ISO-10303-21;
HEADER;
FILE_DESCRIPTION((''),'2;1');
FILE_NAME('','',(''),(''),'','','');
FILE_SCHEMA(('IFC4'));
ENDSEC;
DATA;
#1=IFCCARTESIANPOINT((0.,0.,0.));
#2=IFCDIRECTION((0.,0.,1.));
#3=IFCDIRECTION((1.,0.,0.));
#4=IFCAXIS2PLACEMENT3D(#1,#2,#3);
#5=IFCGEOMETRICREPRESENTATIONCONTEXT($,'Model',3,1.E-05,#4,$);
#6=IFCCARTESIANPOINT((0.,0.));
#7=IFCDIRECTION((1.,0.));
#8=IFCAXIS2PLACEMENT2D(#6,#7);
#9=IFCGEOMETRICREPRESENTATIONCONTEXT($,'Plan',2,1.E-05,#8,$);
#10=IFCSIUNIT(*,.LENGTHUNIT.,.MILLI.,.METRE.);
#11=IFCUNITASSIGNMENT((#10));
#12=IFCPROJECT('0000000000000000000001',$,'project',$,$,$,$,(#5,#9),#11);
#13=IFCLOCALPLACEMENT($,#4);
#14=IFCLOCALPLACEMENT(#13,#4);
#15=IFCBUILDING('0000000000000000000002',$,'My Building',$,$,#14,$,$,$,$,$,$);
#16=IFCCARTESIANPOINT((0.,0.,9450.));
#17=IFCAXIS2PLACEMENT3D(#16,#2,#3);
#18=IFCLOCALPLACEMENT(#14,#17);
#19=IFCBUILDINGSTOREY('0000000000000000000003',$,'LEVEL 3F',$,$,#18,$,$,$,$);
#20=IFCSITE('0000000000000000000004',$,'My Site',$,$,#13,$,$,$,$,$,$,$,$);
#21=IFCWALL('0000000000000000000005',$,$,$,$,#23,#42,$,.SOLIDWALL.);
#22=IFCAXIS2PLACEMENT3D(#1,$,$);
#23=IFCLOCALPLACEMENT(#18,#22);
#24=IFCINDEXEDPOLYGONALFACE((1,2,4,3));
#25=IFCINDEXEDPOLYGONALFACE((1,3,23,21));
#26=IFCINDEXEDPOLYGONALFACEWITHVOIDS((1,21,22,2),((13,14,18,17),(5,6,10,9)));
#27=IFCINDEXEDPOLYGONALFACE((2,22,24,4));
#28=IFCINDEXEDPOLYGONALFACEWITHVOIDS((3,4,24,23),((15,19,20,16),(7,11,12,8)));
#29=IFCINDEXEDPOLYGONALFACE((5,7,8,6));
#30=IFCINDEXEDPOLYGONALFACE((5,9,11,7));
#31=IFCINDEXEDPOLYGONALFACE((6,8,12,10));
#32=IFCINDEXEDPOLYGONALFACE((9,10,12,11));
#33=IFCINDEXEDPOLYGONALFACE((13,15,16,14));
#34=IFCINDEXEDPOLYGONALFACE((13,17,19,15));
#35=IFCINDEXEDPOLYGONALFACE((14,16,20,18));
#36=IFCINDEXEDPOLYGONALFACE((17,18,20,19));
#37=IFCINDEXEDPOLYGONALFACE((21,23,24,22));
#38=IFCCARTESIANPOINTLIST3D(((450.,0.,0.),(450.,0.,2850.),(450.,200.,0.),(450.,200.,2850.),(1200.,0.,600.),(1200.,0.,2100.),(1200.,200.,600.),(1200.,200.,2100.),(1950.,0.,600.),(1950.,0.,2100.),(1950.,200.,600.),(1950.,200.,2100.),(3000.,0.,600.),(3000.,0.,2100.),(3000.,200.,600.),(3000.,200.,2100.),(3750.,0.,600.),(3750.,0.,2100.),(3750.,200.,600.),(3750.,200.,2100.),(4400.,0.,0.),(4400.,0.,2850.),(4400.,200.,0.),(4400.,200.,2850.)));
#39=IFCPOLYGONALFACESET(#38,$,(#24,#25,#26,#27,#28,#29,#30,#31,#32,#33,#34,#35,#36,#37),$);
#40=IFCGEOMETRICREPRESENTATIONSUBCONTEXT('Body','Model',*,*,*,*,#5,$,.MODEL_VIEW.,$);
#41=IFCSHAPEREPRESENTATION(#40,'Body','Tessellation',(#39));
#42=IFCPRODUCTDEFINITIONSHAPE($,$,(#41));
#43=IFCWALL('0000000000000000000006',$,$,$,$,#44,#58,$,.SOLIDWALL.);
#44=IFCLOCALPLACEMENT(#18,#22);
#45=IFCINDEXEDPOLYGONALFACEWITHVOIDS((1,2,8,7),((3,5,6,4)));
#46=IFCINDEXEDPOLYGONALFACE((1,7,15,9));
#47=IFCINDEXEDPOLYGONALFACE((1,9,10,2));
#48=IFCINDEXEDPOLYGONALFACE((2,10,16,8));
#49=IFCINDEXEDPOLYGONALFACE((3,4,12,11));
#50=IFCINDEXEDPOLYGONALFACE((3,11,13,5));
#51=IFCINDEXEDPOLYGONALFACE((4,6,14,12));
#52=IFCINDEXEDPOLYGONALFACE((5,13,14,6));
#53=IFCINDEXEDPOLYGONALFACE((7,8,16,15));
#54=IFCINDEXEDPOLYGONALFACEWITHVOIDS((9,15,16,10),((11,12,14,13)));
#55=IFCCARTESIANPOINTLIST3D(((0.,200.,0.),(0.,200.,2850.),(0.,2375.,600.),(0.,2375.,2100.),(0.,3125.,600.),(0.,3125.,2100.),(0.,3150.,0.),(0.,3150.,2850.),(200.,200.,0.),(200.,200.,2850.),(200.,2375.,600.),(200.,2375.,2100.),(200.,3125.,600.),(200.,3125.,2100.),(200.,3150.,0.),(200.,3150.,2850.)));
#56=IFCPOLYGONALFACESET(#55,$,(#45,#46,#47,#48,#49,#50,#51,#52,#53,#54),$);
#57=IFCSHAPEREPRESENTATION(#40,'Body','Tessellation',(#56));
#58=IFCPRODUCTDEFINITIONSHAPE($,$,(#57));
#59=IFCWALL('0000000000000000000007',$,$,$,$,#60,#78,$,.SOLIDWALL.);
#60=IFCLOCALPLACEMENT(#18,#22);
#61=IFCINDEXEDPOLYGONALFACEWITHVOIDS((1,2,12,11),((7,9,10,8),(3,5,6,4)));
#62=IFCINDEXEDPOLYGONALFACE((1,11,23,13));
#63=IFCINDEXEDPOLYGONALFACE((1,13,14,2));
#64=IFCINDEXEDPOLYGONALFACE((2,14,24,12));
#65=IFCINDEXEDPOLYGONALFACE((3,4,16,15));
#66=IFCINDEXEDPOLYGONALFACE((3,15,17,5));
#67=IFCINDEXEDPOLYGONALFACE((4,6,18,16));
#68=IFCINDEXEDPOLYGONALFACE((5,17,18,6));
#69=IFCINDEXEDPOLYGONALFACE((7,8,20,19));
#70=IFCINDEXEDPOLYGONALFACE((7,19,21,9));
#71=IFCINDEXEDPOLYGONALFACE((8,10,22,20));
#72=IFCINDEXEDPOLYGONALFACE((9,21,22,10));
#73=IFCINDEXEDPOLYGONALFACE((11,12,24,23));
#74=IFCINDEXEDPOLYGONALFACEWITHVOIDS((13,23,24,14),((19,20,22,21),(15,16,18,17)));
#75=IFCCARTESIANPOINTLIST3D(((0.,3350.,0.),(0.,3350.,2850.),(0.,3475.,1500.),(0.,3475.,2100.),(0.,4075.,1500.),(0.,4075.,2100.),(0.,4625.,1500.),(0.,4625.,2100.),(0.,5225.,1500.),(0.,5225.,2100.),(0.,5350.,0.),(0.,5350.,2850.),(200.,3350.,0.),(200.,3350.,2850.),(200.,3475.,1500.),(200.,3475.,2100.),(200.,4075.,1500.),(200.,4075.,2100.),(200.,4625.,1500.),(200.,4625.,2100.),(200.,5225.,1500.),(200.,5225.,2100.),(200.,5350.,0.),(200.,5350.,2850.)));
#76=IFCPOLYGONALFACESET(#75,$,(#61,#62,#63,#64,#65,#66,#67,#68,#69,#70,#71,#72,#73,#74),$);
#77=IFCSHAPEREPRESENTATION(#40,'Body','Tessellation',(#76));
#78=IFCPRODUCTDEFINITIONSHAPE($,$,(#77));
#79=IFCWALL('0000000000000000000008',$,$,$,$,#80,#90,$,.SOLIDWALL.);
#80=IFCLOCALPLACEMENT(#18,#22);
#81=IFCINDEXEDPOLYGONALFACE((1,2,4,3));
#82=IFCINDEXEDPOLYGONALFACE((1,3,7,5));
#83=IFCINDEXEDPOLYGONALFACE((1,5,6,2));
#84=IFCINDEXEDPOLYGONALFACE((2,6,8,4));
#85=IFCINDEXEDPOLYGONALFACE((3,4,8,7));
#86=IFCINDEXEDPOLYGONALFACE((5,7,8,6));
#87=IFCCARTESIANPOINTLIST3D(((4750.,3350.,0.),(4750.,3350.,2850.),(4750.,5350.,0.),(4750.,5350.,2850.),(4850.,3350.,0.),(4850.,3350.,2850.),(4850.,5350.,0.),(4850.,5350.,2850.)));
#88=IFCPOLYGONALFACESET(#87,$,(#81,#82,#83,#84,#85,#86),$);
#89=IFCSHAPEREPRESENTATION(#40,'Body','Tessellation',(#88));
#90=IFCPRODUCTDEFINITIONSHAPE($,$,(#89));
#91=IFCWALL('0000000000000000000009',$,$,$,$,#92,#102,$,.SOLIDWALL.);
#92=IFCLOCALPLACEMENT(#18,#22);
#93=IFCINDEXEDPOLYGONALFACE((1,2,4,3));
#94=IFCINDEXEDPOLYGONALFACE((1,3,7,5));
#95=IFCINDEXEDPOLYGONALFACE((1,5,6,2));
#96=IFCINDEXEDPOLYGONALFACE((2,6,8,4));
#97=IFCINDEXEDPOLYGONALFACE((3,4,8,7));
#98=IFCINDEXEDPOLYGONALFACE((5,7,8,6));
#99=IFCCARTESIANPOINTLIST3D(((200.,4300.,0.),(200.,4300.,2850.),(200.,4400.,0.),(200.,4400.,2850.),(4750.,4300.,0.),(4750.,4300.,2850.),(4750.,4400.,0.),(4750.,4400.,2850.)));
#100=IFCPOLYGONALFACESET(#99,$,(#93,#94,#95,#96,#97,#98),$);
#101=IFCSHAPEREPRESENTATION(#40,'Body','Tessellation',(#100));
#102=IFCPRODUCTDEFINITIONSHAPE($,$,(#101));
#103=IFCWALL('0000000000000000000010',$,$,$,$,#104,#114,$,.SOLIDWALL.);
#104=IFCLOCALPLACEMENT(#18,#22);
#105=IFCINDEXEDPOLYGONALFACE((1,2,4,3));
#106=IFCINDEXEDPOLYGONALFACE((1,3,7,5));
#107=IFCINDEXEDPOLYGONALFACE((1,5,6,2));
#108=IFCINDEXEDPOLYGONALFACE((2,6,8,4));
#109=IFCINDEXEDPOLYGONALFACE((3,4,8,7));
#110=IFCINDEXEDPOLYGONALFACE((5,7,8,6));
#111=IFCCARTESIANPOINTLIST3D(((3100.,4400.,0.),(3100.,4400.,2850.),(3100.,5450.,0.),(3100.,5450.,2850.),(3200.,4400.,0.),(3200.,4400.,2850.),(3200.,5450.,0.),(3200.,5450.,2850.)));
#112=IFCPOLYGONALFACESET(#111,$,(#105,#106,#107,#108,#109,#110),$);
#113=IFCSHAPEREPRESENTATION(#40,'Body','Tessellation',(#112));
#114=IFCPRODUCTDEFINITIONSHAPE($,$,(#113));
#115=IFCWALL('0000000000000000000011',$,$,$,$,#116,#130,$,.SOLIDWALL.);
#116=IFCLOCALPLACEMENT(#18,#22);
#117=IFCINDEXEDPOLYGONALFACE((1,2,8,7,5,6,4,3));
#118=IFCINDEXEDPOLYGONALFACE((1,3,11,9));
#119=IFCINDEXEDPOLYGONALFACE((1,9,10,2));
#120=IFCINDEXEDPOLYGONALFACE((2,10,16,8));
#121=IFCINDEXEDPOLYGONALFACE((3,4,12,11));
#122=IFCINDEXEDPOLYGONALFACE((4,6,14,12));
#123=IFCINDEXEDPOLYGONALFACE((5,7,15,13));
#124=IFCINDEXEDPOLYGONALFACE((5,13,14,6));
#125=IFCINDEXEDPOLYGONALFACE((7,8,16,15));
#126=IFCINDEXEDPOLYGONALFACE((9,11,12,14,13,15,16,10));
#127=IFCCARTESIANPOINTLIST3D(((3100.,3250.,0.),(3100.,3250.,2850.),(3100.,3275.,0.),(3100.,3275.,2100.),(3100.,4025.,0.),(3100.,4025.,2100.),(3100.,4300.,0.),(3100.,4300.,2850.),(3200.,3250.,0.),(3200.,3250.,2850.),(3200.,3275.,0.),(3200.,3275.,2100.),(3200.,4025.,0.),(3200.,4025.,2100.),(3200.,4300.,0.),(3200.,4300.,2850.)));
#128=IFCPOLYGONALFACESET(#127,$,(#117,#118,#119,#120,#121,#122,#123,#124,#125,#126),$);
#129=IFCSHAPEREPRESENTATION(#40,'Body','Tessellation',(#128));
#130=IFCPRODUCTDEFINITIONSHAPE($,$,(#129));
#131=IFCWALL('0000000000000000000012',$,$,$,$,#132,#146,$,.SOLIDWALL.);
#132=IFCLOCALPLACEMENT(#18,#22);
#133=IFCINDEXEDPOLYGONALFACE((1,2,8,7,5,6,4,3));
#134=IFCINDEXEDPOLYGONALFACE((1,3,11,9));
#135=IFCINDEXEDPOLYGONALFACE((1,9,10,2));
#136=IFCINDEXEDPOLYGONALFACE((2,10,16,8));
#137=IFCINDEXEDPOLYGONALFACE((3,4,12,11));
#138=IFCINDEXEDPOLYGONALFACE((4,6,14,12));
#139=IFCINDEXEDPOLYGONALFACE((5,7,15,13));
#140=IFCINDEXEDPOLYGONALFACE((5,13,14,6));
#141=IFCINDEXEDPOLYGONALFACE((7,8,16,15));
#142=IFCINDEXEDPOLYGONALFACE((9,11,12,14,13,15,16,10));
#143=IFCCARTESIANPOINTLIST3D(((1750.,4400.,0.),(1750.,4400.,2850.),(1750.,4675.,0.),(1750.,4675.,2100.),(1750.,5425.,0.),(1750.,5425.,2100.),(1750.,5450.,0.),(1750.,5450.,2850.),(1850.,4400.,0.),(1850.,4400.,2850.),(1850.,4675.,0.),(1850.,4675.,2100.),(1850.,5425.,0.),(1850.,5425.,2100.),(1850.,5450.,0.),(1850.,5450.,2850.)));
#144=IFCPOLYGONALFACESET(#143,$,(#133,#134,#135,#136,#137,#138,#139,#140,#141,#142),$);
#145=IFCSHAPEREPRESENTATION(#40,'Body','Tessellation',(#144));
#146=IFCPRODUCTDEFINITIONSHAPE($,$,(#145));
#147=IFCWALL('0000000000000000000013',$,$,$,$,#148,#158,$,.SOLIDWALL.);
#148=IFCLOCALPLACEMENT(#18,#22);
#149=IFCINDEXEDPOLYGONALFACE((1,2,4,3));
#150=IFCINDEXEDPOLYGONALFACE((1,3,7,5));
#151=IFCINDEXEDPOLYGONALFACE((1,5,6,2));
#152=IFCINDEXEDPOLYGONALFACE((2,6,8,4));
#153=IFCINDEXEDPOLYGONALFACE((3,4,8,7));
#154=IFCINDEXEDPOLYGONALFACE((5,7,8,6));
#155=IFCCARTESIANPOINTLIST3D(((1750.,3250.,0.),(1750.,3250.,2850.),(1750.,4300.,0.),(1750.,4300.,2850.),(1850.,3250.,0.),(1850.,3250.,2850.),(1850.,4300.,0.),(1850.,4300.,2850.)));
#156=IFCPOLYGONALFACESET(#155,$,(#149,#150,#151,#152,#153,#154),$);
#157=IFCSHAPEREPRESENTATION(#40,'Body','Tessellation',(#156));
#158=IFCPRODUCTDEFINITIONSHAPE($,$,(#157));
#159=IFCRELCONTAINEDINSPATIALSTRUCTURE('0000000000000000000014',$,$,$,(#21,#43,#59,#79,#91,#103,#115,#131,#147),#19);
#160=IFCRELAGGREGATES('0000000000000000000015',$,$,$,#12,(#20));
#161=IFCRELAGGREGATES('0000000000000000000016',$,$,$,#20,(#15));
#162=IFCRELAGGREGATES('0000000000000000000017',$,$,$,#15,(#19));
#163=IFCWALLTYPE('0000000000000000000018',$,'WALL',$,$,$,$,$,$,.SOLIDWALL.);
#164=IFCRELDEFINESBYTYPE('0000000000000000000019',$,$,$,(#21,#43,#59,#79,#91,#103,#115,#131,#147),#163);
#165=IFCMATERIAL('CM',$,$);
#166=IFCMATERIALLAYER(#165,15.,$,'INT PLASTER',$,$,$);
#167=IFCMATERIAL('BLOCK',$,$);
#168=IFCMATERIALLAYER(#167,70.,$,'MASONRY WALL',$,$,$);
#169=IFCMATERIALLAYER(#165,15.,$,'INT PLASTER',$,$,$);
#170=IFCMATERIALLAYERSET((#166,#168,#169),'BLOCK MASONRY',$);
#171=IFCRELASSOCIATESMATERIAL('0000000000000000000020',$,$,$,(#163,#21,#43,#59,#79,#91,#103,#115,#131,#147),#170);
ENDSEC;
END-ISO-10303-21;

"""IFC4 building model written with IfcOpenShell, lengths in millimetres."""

from ifc_helpers import new_model, si_unit, frame, origin_with_axes, origin_2d_with_axis, place, context, subcontext, project, spatial, indexed_curve, outline, extrude, material, layer, layer_set, layer_usage, type_object, element, save


model = new_model("IFC4")

# Units and contexts
model_context = context("Model", 3, precision=1e-05, world=origin_with_axes())
plan_context = context("Plan", 2, precision=1e-05, world=origin_2d_with_axis())
body_context = subcontext(model_context, "Body", "Model", "MODEL_VIEW")
ifc_project = project(units=[si_unit("LENGTHUNIT", "METRE", prefix="MILLI")], contexts=[model_context, plan_context])

# Site, building, storey
site_placement = place(None, origin_with_axes())
site = spatial("IfcSite", under=ifc_project, at=site_placement, Name="My Site")
building_placement = place(site_placement, origin_with_axes())
building = spatial("IfcBuilding", under=site, at=building_placement, Name="My Building")
storey_placement = place(building_placement, frame((0.0, 0.0, 9450.0), z_axis=(0.0, 0.0, 1.0), x_axis=(1.0, 0.0, 0.0)))
storey = spatial("IfcBuildingStorey", under=building, at=storey_placement, Name="LEVEL 3F")

# Shared definitions
ifc_material_1 = material(Name="CM")
ifc_layer_1 = layer(ifc_material_1, 15.0, Name="INT PLASTER")
ifc_material_2 = material(Name="BLOCK")
ifc_layer_2 = layer(ifc_material_2, 70.0, Name="MASONRY WALL")
ifc_layer_3 = layer(ifc_material_1, 15.0, Name="INT PLASTER")
ifc_layer_set_1 = layer_set([ifc_layer_1, ifc_layer_2, ifc_layer_3], Name="BLOCK MASONRY")
wall_type = type_object("IfcWallType", Name="WALL", PredefinedType="SOLIDWALL", material=ifc_layer_set_1)

# Wall, openings
ifc_layer_usage_1 = layer_usage(ifc_layer_set_1, "AXIS2", "POSITIVE", 0.0)
wall_1_placement = place(storey_placement, frame((450.0, 200.0, 0.0), z_axis=(0.0, 0.0, 1.0), x_axis=(0.0, -1.0, 0.0)))
wall_1 = element("IfcWall", 1, at=wall_1_placement, inside=storey, type_object=wall_type, material=ifc_layer_usage_1, PredefinedType="SOLIDWALL", context=body_context, shape_type="SweptSolid", body=[
    extrude(outline(indexed_curve([(0.0, 0.0), (0.0, 3950.0), (200.0, 3950.0), (200.0, 0.0), (0.0, 0.0)], self_intersect=False)), origin_with_axes(), (0.0, 0.0, 1.0), 2850.0),
])
opening_1_placement = place(wall_1_placement, frame((0.0, 1500.0, 600.0), z_axis=(0.0, 0.0, 1.0), x_axis=(0.0, -1.0, 0.0)))
element("IfcOpeningElement", 2, at=opening_1_placement, cuts=wall_1, PredefinedType="OPENING", context=body_context, shape_type="SweptSolid", body=[
    extrude(outline(indexed_curve([(0.0, 0.0), (0.0, 400.0), (750.0, 400.0), (750.0, 0.0), (0.0, 0.0)], self_intersect=False)), frame((0.0, -100.0, 0.0), z_axis=(0.0, 0.0, 1.0), x_axis=(1.0, 0.0, 0.0)), (0.0, 0.0, 1.0), 1500.0),
])
opening_2_placement = place(wall_1_placement, frame((0.0, 3300.0, 600.0), z_axis=(0.0, 0.0, 1.0), x_axis=(0.0, -1.0, 0.0)))
element("IfcOpeningElement", 3, at=opening_2_placement, cuts=wall_1, PredefinedType="OPENING", context=body_context, shape_type="SweptSolid", body=[
    extrude(outline(indexed_curve([(0.0, 0.0), (0.0, 400.0), (750.0, 400.0), (750.0, 0.0), (0.0, 0.0)], self_intersect=False)), frame((0.0, -100.0, 0.0), z_axis=(0.0, 0.0, 1.0), x_axis=(1.0, 0.0, 0.0)), (0.0, 0.0, 1.0), 1500.0),
])

# Wall, opening
ifc_layer_usage_2 = layer_usage(ifc_layer_set_1, "AXIS2", "POSITIVE", 0.0)
wall_2_placement = place(storey_placement, frame((200.0, 200.0, 0.0), z_axis=(0.0, 0.0, 1.0), x_axis=(0.0, 1.0, 0.0)))
wall_2 = element("IfcWall", 4, at=wall_2_placement, inside=storey, type_object=wall_type, material=ifc_layer_usage_2, PredefinedType="SOLIDWALL", context=body_context, shape_type="SweptSolid", body=[
    extrude(outline(indexed_curve([(0.0, 0.0), (0.0, 200.0), (2950.0, 200.0), (2950.0, 0.0), (0.0, 0.0)], self_intersect=False)), origin_with_axes(), (0.0, 0.0, 1.0), 2850.0),
])
opening_3_placement = place(wall_2_placement, frame((2175.0, 0.0, 600.0), z_axis=(0.0, 0.0, 1.0), x_axis=(1.0, 0.0, 0.0)))
element("IfcOpeningElement", 5, at=opening_3_placement, cuts=wall_2, PredefinedType="OPENING", context=body_context, shape_type="SweptSolid", body=[
    extrude(outline(indexed_curve([(0.0, 0.0), (0.0, 400.0), (750.0, 400.0), (750.0, 0.0), (0.0, 0.0)], self_intersect=False)), frame((0.0, -100.0, 0.0), z_axis=(0.0, 0.0, 1.0), x_axis=(1.0, 0.0, 0.0)), (0.0, 0.0, 1.0), 1500.0),
])

# Wall, openings
ifc_layer_usage_3 = layer_usage(ifc_layer_set_1, "AXIS2", "POSITIVE", 0.0)
wall_3_placement = place(storey_placement, frame((200.0, 3350.0, 0.0), z_axis=(0.0, 0.0, 1.0), x_axis=(0.0, 1.0, 0.0)))
wall_3 = element("IfcWall", 6, at=wall_3_placement, inside=storey, type_object=wall_type, material=ifc_layer_usage_3, PredefinedType="SOLIDWALL", context=body_context, shape_type="SweptSolid", body=[
    extrude(outline(indexed_curve([(0.0, 0.0), (0.0, 200.0), (2000.0, 200.0), (2000.0, 0.0), (0.0, 0.0)], self_intersect=False)), origin_with_axes(), (0.0, 0.0, 1.0), 2850.0),
])
opening_4_placement = place(wall_3_placement, frame((1275.0, 0.0, 1500.0), z_axis=(0.0, 0.0, 1.0), x_axis=(1.0, 0.0, 0.0)))
element("IfcOpeningElement", 7, at=opening_4_placement, cuts=wall_3, PredefinedType="OPENING", context=body_context, shape_type="SweptSolid", body=[
    extrude(outline(indexed_curve([(0.0, 0.0), (0.0, 400.0), (600.0, 400.0), (600.0, 0.0), (0.0, 0.0)], self_intersect=False)), frame((0.0, -100.0, 0.0), z_axis=(0.0, 0.0, 1.0), x_axis=(1.0, 0.0, 0.0)), (0.0, 0.0, 1.0), 600.0),
])
opening_5_placement = place(wall_3_placement, frame((125.0, 0.0, 1500.0), z_axis=(0.0, 0.0, 1.0), x_axis=(1.0, 0.0, 0.0)))
element("IfcOpeningElement", 8, at=opening_5_placement, cuts=wall_3, PredefinedType="OPENING", context=body_context, shape_type="SweptSolid", body=[
    extrude(outline(indexed_curve([(0.0, 0.0), (0.0, 400.0), (600.0, 400.0), (600.0, 0.0), (0.0, 0.0)], self_intersect=False)), frame((0.0, -100.0, 0.0), z_axis=(0.0, 0.0, 1.0), x_axis=(1.0, 0.0, 0.0)), (0.0, 0.0, 1.0), 600.0),
])

# Walls
ifc_layer_usage_4 = layer_usage(ifc_layer_set_1, "AXIS2", "POSITIVE", 0.0)
wall_4_placement = place(storey_placement, frame((4850.0, 3350.0, 0.0), z_axis=(0.0, 0.0, 1.0), x_axis=(0.0, 1.0, 0.0)))
element("IfcWall", 9, at=wall_4_placement, inside=storey, type_object=wall_type, material=ifc_layer_usage_4, PredefinedType="SOLIDWALL", context=body_context, shape_type="SweptSolid", body=[
    extrude(outline(indexed_curve([(0.0, 0.0), (0.0, 100.0), (2000.0, 100.0), (2000.0, 0.0), (0.0, 0.0)], self_intersect=False)), origin_with_axes(), (0.0, 0.0, 1.0), 2850.0),
])
ifc_layer_usage_5 = layer_usage(ifc_layer_set_1, "AXIS2", "POSITIVE", 0.0)
wall_5_placement = place(storey_placement, frame((200.0, 4400.0, 0.0), z_axis=(0.0, 0.0, 1.0), x_axis=(0.0, -1.0, 0.0)))
element("IfcWall", 10, at=wall_5_placement, inside=storey, type_object=wall_type, material=ifc_layer_usage_5, PredefinedType="SOLIDWALL", context=body_context, shape_type="SweptSolid", body=[
    extrude(outline(indexed_curve([(0.0, 0.0), (0.0, 4550.0), (100.0, 4550.0), (100.0, 0.0), (0.0, 0.0)], self_intersect=False)), origin_with_axes(), (0.0, 0.0, 1.0), 2850.0),
])
ifc_layer_usage_6 = layer_usage(ifc_layer_set_1, "AXIS2", "POSITIVE", 0.0)
wall_6_placement = place(storey_placement, frame((3200.0, 4400.0, 0.0), z_axis=(0.0, 0.0, 1.0), x_axis=(0.0, 1.0, 0.0)))
element("IfcWall", 11, at=wall_6_placement, inside=storey, type_object=wall_type, material=ifc_layer_usage_6, PredefinedType="SOLIDWALL", context=body_context, shape_type="SweptSolid", body=[
    extrude(outline(indexed_curve([(0.0, 0.0), (0.0, 100.0), (1050.0, 100.0), (1050.0, 0.0), (0.0, 0.0)], self_intersect=False)), origin_with_axes(), (0.0, 0.0, 1.0), 2850.0),
])

# Walls, openings
ifc_layer_usage_7 = layer_usage(ifc_layer_set_1, "AXIS2", "POSITIVE", 0.0)
wall_7_placement = place(storey_placement, frame((3200.0, 3250.0, 0.0), z_axis=(0.0, 0.0, 1.0), x_axis=(0.0, 1.0, 0.0)))
wall_7 = element("IfcWall", 12, at=wall_7_placement, inside=storey, type_object=wall_type, material=ifc_layer_usage_7, PredefinedType="SOLIDWALL", context=body_context, shape_type="SweptSolid", body=[
    extrude(outline(indexed_curve([(0.0, 0.0), (0.0, 100.0), (1050.0, 100.0), (1050.0, 0.0), (0.0, 0.0)], self_intersect=False)), origin_with_axes(), (0.0, 0.0, 1.0), 2850.0),
])
opening_6_placement = place(wall_7_placement, frame((775.0, 100.0, 0.0), z_axis=(0.0, 0.0, 1.0), x_axis=(-1.0, 0.0, 0.0)))
element("IfcOpeningElement", 13, at=opening_6_placement, cuts=wall_7, PredefinedType="OPENING", context=body_context, shape_type="SweptSolid", body=[
    extrude(outline(indexed_curve([(0.0, 0.0), (0.0, 400.0), (750.0, 400.0), (750.0, 0.0), (0.0, 0.0)], self_intersect=False)), frame((0.0, -100.0, 0.0), z_axis=(0.0, 0.0, 1.0), x_axis=(1.0, 0.0, 0.0)), (0.0, 0.0, 1.0), 2100.0),
])
ifc_layer_usage_8 = layer_usage(ifc_layer_set_1, "AXIS2", "POSITIVE", 0.0)
wall_8_placement = place(storey_placement, frame((1850.0, 4400.0, 0.0), z_axis=(0.0, 0.0, 1.0), x_axis=(0.0, 1.0, 0.0)))
wall_8 = element("IfcWall", 14, at=wall_8_placement, inside=storey, type_object=wall_type, material=ifc_layer_usage_8, PredefinedType="SOLIDWALL", context=body_context, shape_type="SweptSolid", body=[
    extrude(outline(indexed_curve([(0.0, 0.0), (0.0, 100.0), (1050.0, 100.0), (1050.0, 0.0), (0.0, 0.0)], self_intersect=False)), origin_with_axes(), (0.0, 0.0, 1.0), 2850.0),
])
opening_7_placement = place(wall_8_placement, frame((275.0, 0.0, 0.0), z_axis=(0.0, 0.0, 1.0), x_axis=(1.0, 0.0, 0.0)))
element("IfcOpeningElement", 15, at=opening_7_placement, cuts=wall_8, PredefinedType="OPENING", context=body_context, shape_type="SweptSolid", body=[
    extrude(outline(indexed_curve([(0.0, 0.0), (0.0, 400.0), (750.0, 400.0), (750.0, 0.0), (0.0, 0.0)], self_intersect=False)), frame((0.0, -100.0, 0.0), z_axis=(0.0, 0.0, 1.0), x_axis=(1.0, 0.0, 0.0)), (0.0, 0.0, 1.0), 2100.0),
])

# Wall
ifc_layer_usage_9 = layer_usage(ifc_layer_set_1, "AXIS2", "POSITIVE", 0.0)
wall_9_placement = place(storey_placement, frame((1850.0, 3250.0, 0.0), z_axis=(0.0, 0.0, 1.0), x_axis=(0.0, 1.0, 0.0)))
element("IfcWall", 16, at=wall_9_placement, inside=storey, type_object=wall_type, material=ifc_layer_usage_9, PredefinedType="SOLIDWALL", context=body_context, shape_type="SweptSolid", body=[
    extrude(outline(indexed_curve([(0.0, 0.0), (0.0, 100.0), (1050.0, 100.0), (1050.0, 0.0), (0.0, 0.0)], self_intersect=False)), origin_with_axes(), (0.0, 0.0, 1.0), 2850.0),
])

save(model, "model.ifc")
